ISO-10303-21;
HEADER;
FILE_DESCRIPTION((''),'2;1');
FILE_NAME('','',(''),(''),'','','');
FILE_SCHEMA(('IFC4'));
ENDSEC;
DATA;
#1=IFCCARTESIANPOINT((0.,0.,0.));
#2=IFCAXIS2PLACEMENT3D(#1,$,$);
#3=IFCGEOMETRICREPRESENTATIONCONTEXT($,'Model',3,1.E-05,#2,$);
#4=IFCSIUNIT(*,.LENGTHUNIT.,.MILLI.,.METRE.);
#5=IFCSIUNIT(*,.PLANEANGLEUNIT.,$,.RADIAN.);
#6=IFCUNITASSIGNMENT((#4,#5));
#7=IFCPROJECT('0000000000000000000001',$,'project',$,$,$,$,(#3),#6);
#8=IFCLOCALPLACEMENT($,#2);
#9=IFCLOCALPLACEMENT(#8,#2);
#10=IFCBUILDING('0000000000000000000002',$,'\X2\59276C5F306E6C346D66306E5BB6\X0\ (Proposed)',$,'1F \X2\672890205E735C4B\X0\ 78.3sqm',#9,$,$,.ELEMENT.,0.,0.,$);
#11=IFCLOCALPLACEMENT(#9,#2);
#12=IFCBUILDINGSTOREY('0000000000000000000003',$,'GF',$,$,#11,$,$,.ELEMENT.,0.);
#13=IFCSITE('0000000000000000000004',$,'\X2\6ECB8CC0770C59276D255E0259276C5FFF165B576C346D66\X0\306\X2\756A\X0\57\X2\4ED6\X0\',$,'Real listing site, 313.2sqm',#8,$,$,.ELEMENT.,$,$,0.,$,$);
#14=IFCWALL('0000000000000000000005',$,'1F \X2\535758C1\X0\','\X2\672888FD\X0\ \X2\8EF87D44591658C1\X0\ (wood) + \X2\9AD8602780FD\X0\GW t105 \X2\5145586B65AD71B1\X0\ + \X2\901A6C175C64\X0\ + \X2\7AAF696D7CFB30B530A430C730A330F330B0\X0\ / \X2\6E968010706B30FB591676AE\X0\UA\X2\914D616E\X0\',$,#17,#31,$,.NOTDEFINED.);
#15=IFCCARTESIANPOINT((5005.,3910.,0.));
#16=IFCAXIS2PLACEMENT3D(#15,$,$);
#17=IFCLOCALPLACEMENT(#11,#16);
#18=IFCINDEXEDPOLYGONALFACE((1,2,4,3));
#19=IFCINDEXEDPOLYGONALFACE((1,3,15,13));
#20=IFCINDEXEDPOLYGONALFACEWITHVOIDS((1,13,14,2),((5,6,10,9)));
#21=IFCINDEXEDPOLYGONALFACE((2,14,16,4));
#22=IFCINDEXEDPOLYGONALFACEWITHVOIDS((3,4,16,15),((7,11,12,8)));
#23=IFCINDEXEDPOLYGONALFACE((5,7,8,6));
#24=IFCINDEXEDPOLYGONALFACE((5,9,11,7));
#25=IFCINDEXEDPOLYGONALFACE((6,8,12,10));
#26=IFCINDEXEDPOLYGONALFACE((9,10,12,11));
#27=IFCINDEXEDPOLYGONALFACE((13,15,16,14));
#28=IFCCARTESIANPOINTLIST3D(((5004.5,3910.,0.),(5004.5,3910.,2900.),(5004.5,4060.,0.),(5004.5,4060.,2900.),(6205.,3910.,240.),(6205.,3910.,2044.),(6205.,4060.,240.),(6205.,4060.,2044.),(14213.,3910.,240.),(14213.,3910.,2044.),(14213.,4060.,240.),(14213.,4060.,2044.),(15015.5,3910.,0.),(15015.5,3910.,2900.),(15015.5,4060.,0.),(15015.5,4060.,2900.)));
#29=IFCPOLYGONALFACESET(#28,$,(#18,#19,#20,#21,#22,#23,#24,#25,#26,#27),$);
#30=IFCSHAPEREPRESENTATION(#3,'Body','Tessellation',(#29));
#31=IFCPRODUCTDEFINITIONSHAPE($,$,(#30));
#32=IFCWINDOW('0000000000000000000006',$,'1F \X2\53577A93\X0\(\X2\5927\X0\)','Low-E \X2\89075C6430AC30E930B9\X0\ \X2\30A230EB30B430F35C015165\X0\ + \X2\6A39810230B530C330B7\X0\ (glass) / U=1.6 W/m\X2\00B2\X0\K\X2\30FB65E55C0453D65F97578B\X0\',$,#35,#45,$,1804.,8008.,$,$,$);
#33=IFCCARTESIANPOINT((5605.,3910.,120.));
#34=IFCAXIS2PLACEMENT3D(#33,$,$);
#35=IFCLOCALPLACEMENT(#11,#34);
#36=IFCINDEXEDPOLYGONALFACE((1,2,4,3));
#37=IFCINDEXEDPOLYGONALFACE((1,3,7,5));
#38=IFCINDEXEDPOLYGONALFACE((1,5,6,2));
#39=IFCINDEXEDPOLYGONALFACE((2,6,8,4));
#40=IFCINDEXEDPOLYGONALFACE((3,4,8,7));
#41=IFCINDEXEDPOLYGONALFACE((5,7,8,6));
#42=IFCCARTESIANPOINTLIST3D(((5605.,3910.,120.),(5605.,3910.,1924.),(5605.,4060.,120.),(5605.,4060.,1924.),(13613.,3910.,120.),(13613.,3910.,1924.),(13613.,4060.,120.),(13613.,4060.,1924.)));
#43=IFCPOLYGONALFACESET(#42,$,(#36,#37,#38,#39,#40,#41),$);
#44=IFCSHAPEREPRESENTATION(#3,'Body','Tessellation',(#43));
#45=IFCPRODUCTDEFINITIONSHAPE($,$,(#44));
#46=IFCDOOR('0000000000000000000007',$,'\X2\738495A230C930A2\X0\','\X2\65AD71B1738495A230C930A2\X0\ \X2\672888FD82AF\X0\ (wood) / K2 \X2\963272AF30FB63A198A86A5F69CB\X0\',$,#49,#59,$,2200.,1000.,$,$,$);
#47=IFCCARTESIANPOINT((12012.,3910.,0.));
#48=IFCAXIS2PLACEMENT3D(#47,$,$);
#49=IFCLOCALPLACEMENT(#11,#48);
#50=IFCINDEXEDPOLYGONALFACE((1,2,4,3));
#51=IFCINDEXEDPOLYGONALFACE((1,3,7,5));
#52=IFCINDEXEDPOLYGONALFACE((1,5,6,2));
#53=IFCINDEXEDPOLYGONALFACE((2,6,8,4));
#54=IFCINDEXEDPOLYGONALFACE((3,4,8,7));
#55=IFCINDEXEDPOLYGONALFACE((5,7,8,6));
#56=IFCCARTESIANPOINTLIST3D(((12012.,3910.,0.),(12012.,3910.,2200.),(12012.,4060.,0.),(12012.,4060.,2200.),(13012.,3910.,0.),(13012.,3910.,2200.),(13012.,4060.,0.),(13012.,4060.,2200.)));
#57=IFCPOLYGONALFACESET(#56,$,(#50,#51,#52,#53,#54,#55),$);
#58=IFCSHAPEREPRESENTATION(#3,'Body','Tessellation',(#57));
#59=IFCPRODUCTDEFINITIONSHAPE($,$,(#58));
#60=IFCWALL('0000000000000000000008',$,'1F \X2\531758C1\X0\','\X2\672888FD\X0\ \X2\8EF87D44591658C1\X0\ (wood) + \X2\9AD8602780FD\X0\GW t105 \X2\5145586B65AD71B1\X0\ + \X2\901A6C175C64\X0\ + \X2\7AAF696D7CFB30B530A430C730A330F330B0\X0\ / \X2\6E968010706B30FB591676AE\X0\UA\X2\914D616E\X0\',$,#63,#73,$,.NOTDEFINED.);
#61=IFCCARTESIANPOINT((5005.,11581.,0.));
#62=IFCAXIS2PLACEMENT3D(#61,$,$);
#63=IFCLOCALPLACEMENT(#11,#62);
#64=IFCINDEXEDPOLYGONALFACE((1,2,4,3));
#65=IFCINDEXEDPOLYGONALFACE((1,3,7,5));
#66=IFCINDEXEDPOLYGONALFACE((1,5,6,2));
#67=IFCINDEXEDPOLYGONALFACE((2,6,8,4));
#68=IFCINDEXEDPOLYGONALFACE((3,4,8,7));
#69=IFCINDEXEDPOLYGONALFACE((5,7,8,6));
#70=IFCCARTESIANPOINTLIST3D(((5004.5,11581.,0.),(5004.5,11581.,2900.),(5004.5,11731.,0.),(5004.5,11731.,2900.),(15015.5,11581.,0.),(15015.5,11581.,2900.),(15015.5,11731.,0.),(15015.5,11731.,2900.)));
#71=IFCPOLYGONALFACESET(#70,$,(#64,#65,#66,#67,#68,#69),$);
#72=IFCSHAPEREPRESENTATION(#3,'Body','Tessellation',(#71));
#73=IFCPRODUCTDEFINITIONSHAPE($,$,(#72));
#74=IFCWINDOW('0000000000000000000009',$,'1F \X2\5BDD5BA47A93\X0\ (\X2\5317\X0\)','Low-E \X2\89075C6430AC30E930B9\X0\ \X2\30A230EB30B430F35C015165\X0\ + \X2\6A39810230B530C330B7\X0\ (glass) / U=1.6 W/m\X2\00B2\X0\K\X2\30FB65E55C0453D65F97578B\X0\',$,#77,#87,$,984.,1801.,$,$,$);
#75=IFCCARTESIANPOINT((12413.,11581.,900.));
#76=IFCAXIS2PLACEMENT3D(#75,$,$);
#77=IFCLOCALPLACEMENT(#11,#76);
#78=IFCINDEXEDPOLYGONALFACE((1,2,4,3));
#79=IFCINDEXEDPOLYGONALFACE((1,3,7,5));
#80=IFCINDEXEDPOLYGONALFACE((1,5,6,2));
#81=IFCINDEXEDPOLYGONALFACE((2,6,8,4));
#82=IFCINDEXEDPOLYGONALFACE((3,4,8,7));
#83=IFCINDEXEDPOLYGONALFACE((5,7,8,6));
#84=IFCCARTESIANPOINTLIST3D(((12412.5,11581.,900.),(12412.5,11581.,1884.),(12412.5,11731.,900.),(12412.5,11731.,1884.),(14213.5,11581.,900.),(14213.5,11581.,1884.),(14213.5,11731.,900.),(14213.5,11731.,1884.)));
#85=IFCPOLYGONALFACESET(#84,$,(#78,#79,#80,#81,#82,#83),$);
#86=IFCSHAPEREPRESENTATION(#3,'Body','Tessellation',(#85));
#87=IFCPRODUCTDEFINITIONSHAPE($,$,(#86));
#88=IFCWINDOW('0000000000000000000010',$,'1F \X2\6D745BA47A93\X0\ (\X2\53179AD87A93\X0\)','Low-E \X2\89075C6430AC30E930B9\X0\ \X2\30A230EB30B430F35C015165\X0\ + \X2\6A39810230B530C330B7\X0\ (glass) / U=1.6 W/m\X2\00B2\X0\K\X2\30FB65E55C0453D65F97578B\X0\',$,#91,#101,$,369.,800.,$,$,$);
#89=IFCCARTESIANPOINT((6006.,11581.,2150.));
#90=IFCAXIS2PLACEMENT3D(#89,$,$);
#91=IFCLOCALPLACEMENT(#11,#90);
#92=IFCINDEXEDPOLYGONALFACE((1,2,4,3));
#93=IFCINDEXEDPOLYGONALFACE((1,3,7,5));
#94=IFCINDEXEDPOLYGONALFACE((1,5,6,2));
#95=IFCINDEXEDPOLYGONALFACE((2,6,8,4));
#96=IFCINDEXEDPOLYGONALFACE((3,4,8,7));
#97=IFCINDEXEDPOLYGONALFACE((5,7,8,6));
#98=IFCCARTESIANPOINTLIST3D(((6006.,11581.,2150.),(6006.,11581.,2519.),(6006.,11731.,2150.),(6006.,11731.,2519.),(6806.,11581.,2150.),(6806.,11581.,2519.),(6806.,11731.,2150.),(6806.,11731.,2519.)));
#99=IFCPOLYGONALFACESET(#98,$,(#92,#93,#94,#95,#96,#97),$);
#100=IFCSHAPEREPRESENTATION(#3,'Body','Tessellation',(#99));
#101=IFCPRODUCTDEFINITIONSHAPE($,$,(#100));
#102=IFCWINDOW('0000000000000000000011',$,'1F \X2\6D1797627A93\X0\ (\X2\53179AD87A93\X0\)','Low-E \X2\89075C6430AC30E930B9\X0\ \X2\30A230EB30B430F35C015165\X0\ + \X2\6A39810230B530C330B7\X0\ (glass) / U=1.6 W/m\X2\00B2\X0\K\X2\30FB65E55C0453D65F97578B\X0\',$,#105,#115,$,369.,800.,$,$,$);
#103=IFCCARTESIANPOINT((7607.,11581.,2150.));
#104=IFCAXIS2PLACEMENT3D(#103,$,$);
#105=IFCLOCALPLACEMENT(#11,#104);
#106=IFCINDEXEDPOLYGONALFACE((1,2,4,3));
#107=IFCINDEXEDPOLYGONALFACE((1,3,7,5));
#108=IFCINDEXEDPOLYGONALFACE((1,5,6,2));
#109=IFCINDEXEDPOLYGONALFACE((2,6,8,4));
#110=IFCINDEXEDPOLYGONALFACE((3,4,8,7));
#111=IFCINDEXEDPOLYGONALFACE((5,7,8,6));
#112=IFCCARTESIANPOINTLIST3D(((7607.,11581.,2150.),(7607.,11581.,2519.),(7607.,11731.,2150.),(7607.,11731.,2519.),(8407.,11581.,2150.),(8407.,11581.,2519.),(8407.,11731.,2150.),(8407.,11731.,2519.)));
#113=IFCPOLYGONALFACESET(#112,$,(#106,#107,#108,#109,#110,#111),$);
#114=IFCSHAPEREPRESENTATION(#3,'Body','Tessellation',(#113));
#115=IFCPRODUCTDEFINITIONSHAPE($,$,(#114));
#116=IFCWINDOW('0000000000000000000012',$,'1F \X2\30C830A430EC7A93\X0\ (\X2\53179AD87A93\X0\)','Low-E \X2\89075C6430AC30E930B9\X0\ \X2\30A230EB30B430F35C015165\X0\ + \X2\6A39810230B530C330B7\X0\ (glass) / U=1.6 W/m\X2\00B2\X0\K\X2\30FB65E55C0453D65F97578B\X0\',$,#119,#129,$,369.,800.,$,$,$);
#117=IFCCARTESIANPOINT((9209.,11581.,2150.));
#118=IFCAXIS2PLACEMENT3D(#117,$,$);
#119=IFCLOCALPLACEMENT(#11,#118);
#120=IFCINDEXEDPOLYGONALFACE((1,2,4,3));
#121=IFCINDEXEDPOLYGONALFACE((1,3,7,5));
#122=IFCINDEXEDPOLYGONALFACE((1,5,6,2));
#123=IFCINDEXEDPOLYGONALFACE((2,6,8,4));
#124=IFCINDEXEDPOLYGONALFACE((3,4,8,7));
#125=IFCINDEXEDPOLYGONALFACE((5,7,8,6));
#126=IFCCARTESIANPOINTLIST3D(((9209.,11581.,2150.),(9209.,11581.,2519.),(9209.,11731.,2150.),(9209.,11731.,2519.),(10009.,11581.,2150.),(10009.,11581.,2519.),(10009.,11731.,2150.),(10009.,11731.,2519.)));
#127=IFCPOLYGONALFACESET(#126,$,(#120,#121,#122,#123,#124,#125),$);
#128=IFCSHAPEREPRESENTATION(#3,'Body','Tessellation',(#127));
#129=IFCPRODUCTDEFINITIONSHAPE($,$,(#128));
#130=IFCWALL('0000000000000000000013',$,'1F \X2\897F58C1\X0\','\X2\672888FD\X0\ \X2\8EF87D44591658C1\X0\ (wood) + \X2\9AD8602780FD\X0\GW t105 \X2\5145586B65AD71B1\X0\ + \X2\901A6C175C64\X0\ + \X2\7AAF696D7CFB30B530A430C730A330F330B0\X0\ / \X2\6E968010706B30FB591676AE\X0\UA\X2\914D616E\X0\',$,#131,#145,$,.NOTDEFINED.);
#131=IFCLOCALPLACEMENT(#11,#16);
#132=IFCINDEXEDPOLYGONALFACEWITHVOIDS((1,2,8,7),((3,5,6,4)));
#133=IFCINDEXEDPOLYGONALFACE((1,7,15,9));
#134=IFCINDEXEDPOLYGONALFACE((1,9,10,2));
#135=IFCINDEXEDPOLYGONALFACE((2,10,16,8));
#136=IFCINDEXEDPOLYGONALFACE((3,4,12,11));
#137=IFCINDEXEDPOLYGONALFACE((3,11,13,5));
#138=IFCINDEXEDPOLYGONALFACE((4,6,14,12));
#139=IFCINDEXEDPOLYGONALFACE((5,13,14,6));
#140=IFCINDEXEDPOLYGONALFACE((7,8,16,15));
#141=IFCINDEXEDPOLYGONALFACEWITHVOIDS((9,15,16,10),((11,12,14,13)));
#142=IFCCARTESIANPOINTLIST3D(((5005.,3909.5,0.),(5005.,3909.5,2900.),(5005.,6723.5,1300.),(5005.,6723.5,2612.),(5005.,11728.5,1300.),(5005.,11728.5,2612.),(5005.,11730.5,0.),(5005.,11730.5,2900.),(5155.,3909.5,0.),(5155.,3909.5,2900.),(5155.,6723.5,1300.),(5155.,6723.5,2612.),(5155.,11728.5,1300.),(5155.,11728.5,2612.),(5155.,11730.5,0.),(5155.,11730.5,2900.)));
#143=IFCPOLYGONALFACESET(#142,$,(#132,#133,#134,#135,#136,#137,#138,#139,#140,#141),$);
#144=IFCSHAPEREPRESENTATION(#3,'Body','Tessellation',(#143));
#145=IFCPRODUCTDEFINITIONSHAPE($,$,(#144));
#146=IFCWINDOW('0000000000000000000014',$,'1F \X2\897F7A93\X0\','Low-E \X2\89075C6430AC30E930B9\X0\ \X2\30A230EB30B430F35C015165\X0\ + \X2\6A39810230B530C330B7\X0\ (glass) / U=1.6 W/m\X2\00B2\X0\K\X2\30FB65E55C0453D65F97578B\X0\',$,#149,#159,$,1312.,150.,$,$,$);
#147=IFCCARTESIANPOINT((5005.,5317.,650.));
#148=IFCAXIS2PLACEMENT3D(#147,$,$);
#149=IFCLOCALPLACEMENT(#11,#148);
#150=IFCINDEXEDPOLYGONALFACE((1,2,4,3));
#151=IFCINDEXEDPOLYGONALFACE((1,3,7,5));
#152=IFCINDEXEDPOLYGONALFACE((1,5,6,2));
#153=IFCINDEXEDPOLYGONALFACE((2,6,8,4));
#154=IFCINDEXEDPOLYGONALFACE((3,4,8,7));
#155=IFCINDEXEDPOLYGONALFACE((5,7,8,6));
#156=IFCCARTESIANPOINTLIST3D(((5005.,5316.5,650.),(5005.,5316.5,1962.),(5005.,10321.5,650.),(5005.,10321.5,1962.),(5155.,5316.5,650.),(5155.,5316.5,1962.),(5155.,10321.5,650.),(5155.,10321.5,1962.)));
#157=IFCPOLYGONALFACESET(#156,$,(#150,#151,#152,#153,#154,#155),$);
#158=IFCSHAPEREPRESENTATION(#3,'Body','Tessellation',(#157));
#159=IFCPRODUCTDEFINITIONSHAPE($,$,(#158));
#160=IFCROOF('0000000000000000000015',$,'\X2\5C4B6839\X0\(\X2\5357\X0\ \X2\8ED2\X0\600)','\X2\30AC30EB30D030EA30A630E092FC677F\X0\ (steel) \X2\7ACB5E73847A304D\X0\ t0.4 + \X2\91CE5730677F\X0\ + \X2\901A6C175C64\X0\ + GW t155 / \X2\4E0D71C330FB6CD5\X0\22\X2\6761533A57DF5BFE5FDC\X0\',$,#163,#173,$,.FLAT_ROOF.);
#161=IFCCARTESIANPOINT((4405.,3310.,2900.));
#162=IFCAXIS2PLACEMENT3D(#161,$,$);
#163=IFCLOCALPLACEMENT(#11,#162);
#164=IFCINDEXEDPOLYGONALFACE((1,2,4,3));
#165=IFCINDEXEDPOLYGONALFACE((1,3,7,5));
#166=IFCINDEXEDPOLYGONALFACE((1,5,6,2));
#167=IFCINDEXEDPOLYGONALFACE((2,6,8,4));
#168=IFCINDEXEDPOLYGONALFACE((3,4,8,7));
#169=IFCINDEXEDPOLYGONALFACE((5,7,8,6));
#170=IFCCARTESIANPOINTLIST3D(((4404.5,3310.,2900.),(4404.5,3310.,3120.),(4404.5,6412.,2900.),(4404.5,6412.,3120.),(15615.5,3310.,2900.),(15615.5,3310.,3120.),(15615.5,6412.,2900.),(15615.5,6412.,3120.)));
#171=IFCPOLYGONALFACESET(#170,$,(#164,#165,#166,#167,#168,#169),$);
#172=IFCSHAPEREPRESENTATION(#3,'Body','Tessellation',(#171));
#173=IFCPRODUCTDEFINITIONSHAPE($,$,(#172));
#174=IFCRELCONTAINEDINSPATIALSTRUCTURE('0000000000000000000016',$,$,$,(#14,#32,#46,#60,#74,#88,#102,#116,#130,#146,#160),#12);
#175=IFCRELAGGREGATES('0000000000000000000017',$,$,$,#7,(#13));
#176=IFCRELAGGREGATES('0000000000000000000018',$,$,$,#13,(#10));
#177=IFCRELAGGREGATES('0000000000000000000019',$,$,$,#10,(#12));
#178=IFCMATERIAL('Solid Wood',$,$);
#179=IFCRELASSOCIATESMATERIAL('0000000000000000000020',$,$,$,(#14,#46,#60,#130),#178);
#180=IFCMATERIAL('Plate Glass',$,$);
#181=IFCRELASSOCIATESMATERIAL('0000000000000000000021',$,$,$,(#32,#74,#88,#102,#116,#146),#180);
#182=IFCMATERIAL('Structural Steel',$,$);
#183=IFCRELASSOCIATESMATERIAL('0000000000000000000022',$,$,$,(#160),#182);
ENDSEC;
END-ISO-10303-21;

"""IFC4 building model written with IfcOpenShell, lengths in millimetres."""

from ifc_helpers import new_model, si_unit, frame, frame_2d, origin, place, context, project, spatial, rectangle, extrude, material, element, fill, save


model = new_model("IFC4")

# Units and contexts
model_context = context("Model", 3, precision=1e-05, world=origin())
ifc_project = project(units=[si_unit("LENGTHUNIT", "METRE", prefix="MILLI"), si_unit("PLANEANGLEUNIT", "RADIAN")], contexts=[model_context])

# Site, building, storey
site_placement = place(None, origin())
site = spatial("IfcSite", under=ifc_project, at=site_placement, Name="滋賀県大津市大江６字水浦306番57他", ObjectType="Real listing site, 313.2sqm", CompositionType="ELEMENT", RefElevation=0.0)
building_placement = place(site_placement, origin())
building = spatial("IfcBuilding", under=site, at=building_placement, Name="大江の水浦の家 (Proposed)", ObjectType="1F 木造平屋 78.3sqm", CompositionType="ELEMENT", ElevationOfRefHeight=0.0, ElevationOfTerrain=0.0)
storey_placement = place(building_placement, origin())
storey = spatial("IfcBuildingStorey", under=building, at=storey_placement, Name="GF", CompositionType="ELEMENT", Elevation=0.0)

# Shared definitions
ifc_material_1 = material(Name="Solid Wood")

# Wall, openings, window, door
wall_1_placement = place(storey_placement, frame((5005.0, 3910.0, 0.0)))
wall_1 = element("IfcWall", 1, at=wall_1_placement, inside=storey, material=ifc_material_1, Name="1F 南壁", Description="木製 軸組外壁 (wood) + 高性能GW t105 充填断熱 + 通気層 + 窯業系サイディング / 準耐火・外皮UA配慮", PredefinedType="NOTDEFINED", context=model_context, shape_type="SweptSolid", body=[
    extrude(rectangle(XDim=10011.0, YDim=150.0, at=frame_2d((5005.0, 75.0))), frame((5005.0, 3910.0, 0.0)), (0.0, 0.0, 1.0), 2900.0),
])
opening_1_placement = place(storey_placement, frame((5605.0, 3910.0, 120.0)))
opening_1 = element("IfcOpeningElement", 2, at=opening_1_placement, cuts=wall_1, PredefinedType="NOTDEFINED", context=model_context, shape_type="SweptSolid", body=[
    extrude(rectangle(XDim=8008.0, YDim=150.0, at=frame_2d((4004.0, 75.0))), frame((5605.0, 3910.0, 120.0)), (0.0, 0.0, 1.0), 1804.0),
])
opening_2_placement = place(storey_placement, frame((12012.0, 3910.0, 0.0)))
opening_2 = element("IfcOpeningElement", 3, at=opening_2_placement, cuts=wall_1, PredefinedType="NOTDEFINED", context=model_context, shape_type="SweptSolid", body=[
    extrude(rectangle(XDim=1000.0, YDim=150.0, at=frame_2d((500.0, 75.0))), frame((12012.0, 3910.0, 0.0)), (0.0, 0.0, 1.0), 2200.0),
])
ifc_material_2 = material(Name="Plate Glass")
window_1_placement = place(storey_placement, frame((5605.0, 3910.0, 120.0)))
window_1 = element("IfcWindow", 4, at=window_1_placement, inside=storey, material=ifc_material_2, Name="1F 南窓(大)", Description="Low-E 複層ガラス アルゴン封入 + 樹脂サッシ (glass) / U=1.6 W/m²K・日射取得型", OverallHeight=1804.0, OverallWidth=8008.0, context=model_context, shape_type="SweptSolid", body=[
    extrude(rectangle(XDim=8008.0, YDim=150.0, at=frame_2d((4004.0, 75.0))), frame((5605.0, 3910.0, 120.0)), (0.0, 0.0, 1.0), 1804.0),
])
fill(opening_1, window_1)
door_1_placement = place(storey_placement, frame((12012.0, 3910.0, 0.0)))
door_1 = element("IfcDoor", 5, at=door_1_placement, inside=storey, material=ifc_material_1, Name="玄関ドア", Description="断熱玄関ドア 木製芯 (wood) / K2 防犯・採風機構", OverallHeight=2200.0, OverallWidth=1000.0, context=model_context, shape_type="SweptSolid", body=[
    extrude(rectangle(XDim=1000.0, YDim=150.0, at=frame_2d((500.0, 75.0))), frame((12012.0, 3910.0, 0.0)), (0.0, 0.0, 1.0), 2200.0),
])
fill(opening_2, door_1)

# Wall, openings, windows
wall_2_placement = place(storey_placement, frame((5005.0, 11581.0, 0.0)))
wall_2 = element("IfcWall", 6, at=wall_2_placement, inside=storey, material=ifc_material_1, Name="1F 北壁", Description="木製 軸組外壁 (wood) + 高性能GW t105 充填断熱 + 通気層 + 窯業系サイディング / 準耐火・外皮UA配慮", PredefinedType="NOTDEFINED", context=model_context, shape_type="SweptSolid", body=[
    extrude(rectangle(XDim=10011.0, YDim=150.0, at=frame_2d((5005.0, 75.0))), frame((5005.0, 11581.0, 0.0)), (0.0, 0.0, 1.0), 2900.0),
])
opening_3_placement = place(storey_placement, frame((12413.0, 11581.0, 900.0)))
opening_3 = element("IfcOpeningElement", 7, at=opening_3_placement, cuts=wall_2, PredefinedType="NOTDEFINED", context=model_context, shape_type="SweptSolid", body=[
    extrude(rectangle(XDim=1801.0, YDim=150.0, at=frame_2d((900.0, 75.0))), frame((12413.0, 11581.0, 900.0)), (0.0, 0.0, 1.0), 984.0),
])
opening_4_placement = place(storey_placement, frame((6006.0, 11581.0, 2150.0)))
opening_4 = element("IfcOpeningElement", 8, at=opening_4_placement, cuts=wall_2, PredefinedType="NOTDEFINED", context=model_context, shape_type="SweptSolid", body=[
    extrude(rectangle(XDim=800.0, YDim=150.0, at=frame_2d((400.0, 75.0))), frame((6006.0, 11581.0, 2150.0)), (0.0, 0.0, 1.0), 369.0),
])
opening_5_placement = place(storey_placement, frame((7607.0, 11581.0, 2150.0)))
opening_5 = element("IfcOpeningElement", 9, at=opening_5_placement, cuts=wall_2, PredefinedType="NOTDEFINED", context=model_context, shape_type="SweptSolid", body=[
    extrude(rectangle(XDim=800.0, YDim=150.0, at=frame_2d((400.0, 75.0))), frame((7607.0, 11581.0, 2150.0)), (0.0, 0.0, 1.0), 369.0),
])
opening_6_placement = place(storey_placement, frame((9209.0, 11581.0, 2150.0)))
opening_6 = element("IfcOpeningElement", 10, at=opening_6_placement, cuts=wall_2, PredefinedType="NOTDEFINED", context=model_context, shape_type="SweptSolid", body=[
    extrude(rectangle(XDim=800.0, YDim=150.0, at=frame_2d((400.0, 75.0))), frame((9209.0, 11581.0, 2150.0)), (0.0, 0.0, 1.0), 369.0),
])
window_2_placement = place(storey_placement, frame((12413.0, 11581.0, 900.0)))
window_2 = element("IfcWindow", 11, at=window_2_placement, inside=storey, material=ifc_material_2, Name="1F 寝室窓 (北)", Description="Low-E 複層ガラス アルゴン封入 + 樹脂サッシ (glass) / U=1.6 W/m²K・日射取得型", OverallHeight=984.0, OverallWidth=1801.0, context=model_context, shape_type="SweptSolid", body=[
    extrude(rectangle(XDim=1801.0, YDim=150.0, at=frame_2d((900.0, 75.0))), frame((12413.0, 11581.0, 900.0)), (0.0, 0.0, 1.0), 984.0),
])
fill(opening_3, window_2)
window_3_placement = place(storey_placement, frame((6006.0, 11581.0, 2150.0)))
window_3 = element("IfcWindow", 12, at=window_3_placement, inside=storey, material=ifc_material_2, Name="1F 浴室窓 (北高窓)", Description="Low-E 複層ガラス アルゴン封入 + 樹脂サッシ (glass) / U=1.6 W/m²K・日射取得型", OverallHeight=369.0, OverallWidth=800.0, context=model_context, shape_type="SweptSolid", body=[
    extrude(rectangle(XDim=800.0, YDim=150.0, at=frame_2d((400.0, 75.0))), frame((6006.0, 11581.0, 2150.0)), (0.0, 0.0, 1.0), 369.0),
])
fill(opening_4, window_3)
window_4_placement = place(storey_placement, frame((7607.0, 11581.0, 2150.0)))
window_4 = element("IfcWindow", 13, at=window_4_placement, inside=storey, material=ifc_material_2, Name="1F 洗面窓 (北高窓)", Description="Low-E 複層ガラス アルゴン封入 + 樹脂サッシ (glass) / U=1.6 W/m²K・日射取得型", OverallHeight=369.0, OverallWidth=800.0, context=model_context, shape_type="SweptSolid", body=[
    extrude(rectangle(XDim=800.0, YDim=150.0, at=frame_2d((400.0, 75.0))), frame((7607.0, 11581.0, 2150.0)), (0.0, 0.0, 1.0), 369.0),
])
fill(opening_5, window_4)
window_5_placement = place(storey_placement, frame((9209.0, 11581.0, 2150.0)))
window_5 = element("IfcWindow", 14, at=window_5_placement, inside=storey, material=ifc_material_2, Name="1F トイレ窓 (北高窓)", Description="Low-E 複層ガラス アルゴン封入 + 樹脂サッシ (glass) / U=1.6 W/m²K・日射取得型", OverallHeight=369.0, OverallWidth=800.0, context=model_context, shape_type="SweptSolid", body=[
    extrude(rectangle(XDim=800.0, YDim=150.0, at=frame_2d((400.0, 75.0))), frame((9209.0, 11581.0, 2150.0)), (0.0, 0.0, 1.0), 369.0),
])
fill(opening_6, window_5)

# Wall, opening, window
wall_3_placement = place(storey_placement, frame((5005.0, 3910.0, 0.0)))
wall_3 = element("IfcWall", 15, at=wall_3_placement, inside=storey, material=ifc_material_1, Name="1F 西壁", Description="木製 軸組外壁 (wood) + 高性能GW t105 充填断熱 + 通気層 + 窯業系サイディング / 準耐火・外皮UA配慮", PredefinedType="NOTDEFINED", context=model_context, shape_type="SweptSolid", body=[
    extrude(rectangle(XDim=150.0, YDim=7821.0, at=frame_2d((75.0, 3910.0))), frame((5005.0, 3910.0, 0.0)), (0.0, 0.0, 1.0), 2900.0),
])
opening_7_placement = place(storey_placement, frame((5005.0, 5317.0, 650.0)))
opening_7 = element("IfcOpeningElement", 16, at=opening_7_placement, cuts=wall_3, PredefinedType="NOTDEFINED", context=model_context, shape_type="SweptSolid", body=[
    extrude(rectangle(XDim=150.0, YDim=5005.0, at=frame_2d((75.0, 2502.0))), frame((5005.0, 5317.0, 650.0)), (0.0, 0.0, 1.0), 1312.0),
])
window_6_placement = place(storey_placement, frame((5005.0, 5317.0, 650.0)))
window_6 = element("IfcWindow", 17, at=window_6_placement, inside=storey, material=ifc_material_2, Name="1F 西窓", Description="Low-E 複層ガラス アルゴン封入 + 樹脂サッシ (glass) / U=1.6 W/m²K・日射取得型", OverallHeight=1312.0, OverallWidth=150.0, context=model_context, shape_type="SweptSolid", body=[
    extrude(rectangle(XDim=150.0, YDim=5005.0, at=frame_2d((75.0, 2502.0))), frame((5005.0, 5317.0, 650.0)), (0.0, 0.0, 1.0), 1312.0),
])
fill(opening_7, window_6)

# Roof
ifc_material_3 = material(Name="Structural Steel")
roof_1_placement = place(storey_placement, frame((4405.0, 3310.0, 2900.0)))
element("IfcRoof", 18, at=roof_1_placement, inside=storey, material=ifc_material_3, Name="屋根(南 軒600)", Description="ガルバリウム鋼板 (steel) 立平葺き t0.4 + 野地板 + 通気層 + GW t155 / 不燃・法22条区域対応", PredefinedType="FLAT_ROOF", context=model_context, shape_type="SweptSolid", body=[
    extrude(rectangle(XDim=11211.0, YDim=3102.0, at=frame_2d((5605.0, 1551.0))), frame((4405.0, 3310.0, 2900.0)), (0.0, 0.0, 1.0), 220.0),
])

save(model, "model.ifc")
